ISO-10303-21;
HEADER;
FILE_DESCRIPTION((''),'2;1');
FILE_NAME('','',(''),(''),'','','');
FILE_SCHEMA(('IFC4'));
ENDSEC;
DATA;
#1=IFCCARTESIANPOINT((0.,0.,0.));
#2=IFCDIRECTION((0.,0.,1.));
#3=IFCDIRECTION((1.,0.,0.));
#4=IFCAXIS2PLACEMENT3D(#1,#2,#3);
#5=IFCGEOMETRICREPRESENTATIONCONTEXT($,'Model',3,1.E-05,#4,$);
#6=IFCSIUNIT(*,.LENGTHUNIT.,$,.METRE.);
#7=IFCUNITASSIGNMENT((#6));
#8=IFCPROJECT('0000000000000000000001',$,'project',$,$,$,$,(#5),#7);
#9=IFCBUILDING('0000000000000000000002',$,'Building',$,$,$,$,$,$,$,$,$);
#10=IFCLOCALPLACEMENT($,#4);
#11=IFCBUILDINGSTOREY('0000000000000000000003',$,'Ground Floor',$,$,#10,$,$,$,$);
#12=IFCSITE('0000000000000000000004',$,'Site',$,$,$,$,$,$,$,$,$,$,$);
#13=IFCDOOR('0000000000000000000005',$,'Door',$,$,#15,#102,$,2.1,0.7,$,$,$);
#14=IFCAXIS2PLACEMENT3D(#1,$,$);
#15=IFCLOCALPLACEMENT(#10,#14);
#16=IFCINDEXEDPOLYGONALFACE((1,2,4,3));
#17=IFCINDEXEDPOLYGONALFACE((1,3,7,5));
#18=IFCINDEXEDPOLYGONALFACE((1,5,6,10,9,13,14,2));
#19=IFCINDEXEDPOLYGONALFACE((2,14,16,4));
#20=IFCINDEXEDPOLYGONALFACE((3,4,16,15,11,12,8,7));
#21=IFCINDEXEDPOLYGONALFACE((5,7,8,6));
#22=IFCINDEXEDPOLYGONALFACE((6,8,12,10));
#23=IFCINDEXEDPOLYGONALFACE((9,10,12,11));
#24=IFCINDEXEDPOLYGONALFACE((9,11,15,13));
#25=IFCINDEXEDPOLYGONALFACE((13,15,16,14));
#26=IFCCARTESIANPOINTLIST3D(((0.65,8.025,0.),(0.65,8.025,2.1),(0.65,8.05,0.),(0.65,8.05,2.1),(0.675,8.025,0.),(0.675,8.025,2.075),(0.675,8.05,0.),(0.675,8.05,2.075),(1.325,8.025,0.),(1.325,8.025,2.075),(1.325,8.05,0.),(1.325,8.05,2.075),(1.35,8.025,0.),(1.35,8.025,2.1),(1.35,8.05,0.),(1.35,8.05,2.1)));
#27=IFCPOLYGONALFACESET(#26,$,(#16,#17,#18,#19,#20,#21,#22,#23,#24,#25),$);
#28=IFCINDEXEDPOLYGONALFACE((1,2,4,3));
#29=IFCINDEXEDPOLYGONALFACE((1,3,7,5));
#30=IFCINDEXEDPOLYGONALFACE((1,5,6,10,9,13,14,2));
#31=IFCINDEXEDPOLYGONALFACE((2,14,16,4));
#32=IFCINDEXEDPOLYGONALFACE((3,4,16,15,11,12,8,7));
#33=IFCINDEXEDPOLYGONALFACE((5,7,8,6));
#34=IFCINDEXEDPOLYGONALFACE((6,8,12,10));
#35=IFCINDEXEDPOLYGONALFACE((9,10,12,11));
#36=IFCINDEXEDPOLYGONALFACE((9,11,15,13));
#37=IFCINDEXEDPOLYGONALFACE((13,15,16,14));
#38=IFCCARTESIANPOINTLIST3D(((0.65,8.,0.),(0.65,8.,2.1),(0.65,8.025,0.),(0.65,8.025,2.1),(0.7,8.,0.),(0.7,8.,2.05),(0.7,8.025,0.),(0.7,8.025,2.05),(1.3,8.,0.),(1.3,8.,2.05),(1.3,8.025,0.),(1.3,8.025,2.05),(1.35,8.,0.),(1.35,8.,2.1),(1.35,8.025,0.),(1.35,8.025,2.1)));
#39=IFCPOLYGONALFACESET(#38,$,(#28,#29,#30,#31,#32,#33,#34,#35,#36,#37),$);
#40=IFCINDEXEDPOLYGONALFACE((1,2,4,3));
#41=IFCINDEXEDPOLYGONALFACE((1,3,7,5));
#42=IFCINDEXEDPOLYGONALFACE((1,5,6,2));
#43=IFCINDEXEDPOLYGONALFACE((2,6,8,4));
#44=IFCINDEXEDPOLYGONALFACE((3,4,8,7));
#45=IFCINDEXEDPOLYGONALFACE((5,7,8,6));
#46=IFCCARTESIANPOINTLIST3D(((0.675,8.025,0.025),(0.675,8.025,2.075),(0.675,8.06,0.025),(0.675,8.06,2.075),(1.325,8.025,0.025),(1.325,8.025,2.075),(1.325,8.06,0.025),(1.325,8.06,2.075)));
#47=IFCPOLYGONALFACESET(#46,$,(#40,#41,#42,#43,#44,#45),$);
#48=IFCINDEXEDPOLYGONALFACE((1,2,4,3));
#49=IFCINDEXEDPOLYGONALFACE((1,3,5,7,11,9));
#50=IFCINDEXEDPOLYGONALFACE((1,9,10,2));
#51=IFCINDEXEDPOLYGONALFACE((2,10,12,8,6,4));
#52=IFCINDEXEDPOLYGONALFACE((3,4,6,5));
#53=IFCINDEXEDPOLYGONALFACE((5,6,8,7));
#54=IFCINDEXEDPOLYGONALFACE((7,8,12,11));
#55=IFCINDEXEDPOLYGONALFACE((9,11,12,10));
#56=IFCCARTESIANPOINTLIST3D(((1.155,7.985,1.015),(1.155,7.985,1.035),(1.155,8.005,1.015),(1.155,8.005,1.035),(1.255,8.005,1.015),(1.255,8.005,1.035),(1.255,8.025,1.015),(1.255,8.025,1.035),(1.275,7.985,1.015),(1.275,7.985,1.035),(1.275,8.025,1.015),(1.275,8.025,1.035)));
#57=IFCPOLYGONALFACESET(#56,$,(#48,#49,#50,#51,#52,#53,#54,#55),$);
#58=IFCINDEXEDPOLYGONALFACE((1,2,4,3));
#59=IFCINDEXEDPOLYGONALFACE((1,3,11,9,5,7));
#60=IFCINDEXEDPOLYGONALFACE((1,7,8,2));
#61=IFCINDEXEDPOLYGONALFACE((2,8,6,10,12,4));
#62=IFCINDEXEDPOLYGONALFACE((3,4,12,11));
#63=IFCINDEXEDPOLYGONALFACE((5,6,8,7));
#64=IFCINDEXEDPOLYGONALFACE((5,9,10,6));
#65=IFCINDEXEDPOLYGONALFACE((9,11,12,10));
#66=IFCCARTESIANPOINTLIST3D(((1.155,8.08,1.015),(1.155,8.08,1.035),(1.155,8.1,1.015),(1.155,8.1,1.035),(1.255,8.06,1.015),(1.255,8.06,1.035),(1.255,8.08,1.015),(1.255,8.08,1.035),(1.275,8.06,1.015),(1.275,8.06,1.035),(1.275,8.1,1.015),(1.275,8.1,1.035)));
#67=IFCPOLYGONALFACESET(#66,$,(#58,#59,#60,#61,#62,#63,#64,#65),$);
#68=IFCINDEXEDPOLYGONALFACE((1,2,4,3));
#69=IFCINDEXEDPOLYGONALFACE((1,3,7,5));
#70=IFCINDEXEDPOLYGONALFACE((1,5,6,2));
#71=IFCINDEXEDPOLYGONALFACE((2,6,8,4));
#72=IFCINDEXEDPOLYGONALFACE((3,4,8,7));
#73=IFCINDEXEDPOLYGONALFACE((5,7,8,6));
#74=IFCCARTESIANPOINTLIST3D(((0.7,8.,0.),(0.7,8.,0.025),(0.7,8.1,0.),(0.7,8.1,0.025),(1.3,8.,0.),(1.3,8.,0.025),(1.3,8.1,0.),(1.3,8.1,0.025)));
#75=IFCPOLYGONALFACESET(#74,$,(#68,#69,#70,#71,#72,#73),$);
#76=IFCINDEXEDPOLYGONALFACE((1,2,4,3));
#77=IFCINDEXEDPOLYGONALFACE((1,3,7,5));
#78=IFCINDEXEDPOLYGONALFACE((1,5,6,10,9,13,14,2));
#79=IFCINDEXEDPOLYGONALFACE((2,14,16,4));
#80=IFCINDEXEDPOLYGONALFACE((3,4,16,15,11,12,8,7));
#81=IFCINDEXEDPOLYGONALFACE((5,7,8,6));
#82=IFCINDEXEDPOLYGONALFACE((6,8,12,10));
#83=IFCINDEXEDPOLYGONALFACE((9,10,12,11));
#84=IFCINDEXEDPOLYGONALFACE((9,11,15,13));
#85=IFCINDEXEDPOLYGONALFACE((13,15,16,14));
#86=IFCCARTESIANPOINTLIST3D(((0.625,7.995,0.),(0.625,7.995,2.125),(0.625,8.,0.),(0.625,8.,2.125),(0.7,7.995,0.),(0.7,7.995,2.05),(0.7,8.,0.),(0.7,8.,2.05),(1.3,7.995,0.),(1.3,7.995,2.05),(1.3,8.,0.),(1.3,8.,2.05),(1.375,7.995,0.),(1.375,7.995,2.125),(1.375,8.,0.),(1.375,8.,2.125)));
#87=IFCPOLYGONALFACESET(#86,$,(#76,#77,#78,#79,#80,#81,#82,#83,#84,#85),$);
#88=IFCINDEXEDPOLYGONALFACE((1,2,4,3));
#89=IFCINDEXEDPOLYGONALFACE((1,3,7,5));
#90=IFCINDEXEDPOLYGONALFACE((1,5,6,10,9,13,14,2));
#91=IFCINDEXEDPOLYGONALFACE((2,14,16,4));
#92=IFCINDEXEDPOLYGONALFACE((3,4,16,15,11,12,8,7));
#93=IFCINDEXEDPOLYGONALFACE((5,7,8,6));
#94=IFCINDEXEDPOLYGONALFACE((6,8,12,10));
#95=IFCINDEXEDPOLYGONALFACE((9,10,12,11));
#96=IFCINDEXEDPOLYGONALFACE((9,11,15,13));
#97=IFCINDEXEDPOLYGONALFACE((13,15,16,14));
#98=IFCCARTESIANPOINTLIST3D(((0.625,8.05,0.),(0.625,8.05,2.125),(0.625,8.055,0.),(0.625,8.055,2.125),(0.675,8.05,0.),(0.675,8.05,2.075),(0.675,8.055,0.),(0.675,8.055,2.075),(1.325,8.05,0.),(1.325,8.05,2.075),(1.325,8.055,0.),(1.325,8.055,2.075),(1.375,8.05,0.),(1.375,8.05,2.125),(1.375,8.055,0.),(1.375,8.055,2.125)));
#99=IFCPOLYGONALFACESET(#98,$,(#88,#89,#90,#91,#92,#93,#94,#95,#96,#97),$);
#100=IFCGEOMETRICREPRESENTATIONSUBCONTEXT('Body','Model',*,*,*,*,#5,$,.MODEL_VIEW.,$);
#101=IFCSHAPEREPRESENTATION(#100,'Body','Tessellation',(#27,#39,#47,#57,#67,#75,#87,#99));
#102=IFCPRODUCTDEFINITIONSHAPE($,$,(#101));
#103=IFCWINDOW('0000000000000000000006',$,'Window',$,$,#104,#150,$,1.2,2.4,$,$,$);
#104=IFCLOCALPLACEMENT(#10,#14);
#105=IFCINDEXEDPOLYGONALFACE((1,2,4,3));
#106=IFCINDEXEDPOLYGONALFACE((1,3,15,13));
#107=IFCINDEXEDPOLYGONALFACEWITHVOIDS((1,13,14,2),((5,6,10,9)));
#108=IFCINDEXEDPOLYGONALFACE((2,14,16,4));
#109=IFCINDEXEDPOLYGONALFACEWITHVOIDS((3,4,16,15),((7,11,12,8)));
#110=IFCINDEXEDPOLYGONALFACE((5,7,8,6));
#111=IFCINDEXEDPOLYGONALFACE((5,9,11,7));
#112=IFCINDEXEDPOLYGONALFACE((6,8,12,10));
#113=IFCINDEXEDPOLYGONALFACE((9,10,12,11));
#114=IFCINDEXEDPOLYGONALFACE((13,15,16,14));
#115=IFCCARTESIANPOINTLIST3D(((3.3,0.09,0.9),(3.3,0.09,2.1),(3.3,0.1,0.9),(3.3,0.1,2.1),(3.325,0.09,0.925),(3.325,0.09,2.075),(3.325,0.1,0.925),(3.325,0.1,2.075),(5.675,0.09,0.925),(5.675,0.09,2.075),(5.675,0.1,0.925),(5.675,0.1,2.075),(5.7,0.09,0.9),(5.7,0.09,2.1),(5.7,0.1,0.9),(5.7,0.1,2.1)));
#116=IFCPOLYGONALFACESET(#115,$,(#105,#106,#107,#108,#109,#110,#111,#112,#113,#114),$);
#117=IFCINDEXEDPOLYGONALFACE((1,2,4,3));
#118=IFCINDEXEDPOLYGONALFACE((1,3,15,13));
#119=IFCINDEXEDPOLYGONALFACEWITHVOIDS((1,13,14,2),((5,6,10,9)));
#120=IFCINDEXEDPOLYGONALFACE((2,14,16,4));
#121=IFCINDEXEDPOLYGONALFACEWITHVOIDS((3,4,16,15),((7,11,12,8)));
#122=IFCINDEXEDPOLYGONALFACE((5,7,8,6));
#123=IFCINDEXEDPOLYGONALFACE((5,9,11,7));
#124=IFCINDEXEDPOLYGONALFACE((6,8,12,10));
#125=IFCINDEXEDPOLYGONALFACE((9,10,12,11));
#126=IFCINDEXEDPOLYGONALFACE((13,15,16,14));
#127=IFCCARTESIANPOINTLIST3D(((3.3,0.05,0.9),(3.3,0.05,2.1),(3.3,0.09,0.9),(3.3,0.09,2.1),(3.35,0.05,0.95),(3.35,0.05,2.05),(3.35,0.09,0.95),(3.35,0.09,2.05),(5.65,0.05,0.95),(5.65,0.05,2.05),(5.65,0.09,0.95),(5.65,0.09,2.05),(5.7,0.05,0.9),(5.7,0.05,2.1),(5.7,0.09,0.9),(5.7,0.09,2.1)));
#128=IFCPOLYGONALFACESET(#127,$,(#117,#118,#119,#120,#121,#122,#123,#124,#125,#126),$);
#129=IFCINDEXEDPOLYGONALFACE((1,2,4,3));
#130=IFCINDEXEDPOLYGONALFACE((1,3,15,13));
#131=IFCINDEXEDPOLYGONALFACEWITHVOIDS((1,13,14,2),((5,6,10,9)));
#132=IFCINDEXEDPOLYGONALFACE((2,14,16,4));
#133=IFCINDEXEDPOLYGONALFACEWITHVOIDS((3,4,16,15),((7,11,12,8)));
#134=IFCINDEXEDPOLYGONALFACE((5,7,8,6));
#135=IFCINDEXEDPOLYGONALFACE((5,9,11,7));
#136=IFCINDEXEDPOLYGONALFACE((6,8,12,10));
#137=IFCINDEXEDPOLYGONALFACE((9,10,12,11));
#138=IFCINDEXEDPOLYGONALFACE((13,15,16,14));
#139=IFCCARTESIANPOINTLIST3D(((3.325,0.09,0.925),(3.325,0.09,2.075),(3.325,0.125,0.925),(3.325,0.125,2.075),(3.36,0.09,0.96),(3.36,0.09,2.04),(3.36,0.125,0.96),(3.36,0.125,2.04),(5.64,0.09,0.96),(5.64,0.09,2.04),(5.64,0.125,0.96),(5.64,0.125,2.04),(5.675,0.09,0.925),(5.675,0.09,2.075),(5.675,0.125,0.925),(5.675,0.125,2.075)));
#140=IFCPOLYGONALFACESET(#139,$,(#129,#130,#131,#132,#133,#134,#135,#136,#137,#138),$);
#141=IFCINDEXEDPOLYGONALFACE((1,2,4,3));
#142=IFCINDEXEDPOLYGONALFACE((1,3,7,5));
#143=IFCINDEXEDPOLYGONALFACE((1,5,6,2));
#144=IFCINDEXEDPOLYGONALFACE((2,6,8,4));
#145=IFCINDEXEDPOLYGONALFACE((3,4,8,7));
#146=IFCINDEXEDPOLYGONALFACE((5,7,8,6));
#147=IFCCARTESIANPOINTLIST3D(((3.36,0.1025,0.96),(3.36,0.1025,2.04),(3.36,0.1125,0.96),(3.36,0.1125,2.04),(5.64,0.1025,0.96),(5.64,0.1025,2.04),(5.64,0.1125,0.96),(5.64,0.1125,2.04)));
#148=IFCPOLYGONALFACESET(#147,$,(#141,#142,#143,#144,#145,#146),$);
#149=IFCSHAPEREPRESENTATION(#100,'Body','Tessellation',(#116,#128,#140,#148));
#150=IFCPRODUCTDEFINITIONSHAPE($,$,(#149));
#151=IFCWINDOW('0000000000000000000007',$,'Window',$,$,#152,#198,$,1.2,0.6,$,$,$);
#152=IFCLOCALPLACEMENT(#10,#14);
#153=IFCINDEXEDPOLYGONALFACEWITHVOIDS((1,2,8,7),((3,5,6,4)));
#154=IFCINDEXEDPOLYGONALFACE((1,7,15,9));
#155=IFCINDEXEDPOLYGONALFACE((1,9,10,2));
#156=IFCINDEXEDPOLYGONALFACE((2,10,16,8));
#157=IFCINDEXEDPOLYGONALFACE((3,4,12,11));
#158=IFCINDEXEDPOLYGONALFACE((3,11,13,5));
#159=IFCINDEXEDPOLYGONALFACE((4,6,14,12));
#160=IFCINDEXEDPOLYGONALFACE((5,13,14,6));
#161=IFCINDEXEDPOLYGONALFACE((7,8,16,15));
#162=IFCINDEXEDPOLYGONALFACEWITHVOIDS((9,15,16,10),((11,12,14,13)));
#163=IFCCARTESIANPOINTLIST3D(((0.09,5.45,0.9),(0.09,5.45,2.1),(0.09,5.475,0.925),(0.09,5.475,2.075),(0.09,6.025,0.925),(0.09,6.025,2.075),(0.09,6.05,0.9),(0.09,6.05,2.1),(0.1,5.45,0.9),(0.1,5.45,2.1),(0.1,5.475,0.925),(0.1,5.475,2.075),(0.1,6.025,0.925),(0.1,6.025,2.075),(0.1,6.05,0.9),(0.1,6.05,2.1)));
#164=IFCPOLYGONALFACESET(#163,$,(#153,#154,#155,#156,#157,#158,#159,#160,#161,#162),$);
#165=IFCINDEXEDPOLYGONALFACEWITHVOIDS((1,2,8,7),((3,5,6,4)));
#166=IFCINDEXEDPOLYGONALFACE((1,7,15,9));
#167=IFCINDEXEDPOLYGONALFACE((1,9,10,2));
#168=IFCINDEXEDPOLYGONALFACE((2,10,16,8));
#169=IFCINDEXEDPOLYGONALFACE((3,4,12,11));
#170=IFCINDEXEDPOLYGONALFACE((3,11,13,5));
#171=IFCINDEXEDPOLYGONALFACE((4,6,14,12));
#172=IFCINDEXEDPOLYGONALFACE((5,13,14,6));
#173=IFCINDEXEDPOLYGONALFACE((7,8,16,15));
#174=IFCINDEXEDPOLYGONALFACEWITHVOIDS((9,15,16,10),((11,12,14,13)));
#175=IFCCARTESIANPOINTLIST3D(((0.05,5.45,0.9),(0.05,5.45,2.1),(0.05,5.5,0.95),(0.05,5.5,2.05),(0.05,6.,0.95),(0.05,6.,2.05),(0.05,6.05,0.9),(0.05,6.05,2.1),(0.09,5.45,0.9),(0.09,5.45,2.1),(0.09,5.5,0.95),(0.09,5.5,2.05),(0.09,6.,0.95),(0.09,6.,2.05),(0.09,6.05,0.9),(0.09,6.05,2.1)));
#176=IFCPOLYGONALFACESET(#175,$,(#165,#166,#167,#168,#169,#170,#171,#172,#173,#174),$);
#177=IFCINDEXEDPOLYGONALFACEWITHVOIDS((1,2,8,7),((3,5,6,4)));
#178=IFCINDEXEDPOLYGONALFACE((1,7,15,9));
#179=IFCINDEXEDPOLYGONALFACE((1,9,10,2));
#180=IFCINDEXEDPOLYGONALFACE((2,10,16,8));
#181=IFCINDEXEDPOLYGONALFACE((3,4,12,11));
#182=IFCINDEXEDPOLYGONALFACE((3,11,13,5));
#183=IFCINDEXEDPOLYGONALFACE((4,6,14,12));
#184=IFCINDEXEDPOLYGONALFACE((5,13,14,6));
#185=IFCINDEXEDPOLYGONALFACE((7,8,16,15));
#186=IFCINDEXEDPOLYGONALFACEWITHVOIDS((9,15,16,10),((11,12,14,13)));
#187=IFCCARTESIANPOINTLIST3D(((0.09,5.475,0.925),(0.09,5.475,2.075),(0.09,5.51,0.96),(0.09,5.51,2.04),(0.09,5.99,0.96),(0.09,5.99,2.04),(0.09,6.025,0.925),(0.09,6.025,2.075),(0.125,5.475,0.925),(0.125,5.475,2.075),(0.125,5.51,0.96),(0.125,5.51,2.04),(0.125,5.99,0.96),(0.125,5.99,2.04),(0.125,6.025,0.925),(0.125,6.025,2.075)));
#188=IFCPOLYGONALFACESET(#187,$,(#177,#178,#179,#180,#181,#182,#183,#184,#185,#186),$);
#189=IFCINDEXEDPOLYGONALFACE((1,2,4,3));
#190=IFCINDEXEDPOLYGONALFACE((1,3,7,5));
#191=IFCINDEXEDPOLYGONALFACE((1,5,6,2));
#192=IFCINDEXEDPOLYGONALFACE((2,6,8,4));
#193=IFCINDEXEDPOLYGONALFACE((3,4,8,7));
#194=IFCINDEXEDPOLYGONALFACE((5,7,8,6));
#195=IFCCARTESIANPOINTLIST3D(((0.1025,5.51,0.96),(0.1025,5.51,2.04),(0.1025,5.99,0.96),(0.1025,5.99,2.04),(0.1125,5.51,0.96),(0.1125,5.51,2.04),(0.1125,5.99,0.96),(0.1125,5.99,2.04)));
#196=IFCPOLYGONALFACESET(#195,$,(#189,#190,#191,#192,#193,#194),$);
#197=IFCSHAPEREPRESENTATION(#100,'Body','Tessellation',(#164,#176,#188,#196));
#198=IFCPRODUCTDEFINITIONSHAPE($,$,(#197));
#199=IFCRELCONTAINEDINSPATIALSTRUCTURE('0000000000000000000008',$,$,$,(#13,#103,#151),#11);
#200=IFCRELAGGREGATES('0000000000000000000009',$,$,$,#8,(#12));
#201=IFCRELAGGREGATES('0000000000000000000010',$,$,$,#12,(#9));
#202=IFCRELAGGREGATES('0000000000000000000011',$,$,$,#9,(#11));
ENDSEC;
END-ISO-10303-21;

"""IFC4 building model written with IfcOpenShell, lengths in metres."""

from ifc_helpers import new_model, si_unit, frame, origin_with_axes, place, context, subcontext, project, spatial, line, indexed_curve, outline, extrude, element, save


model = new_model("IFC4")

# Units and contexts
model_context = context("Model", 3, precision=1e-05, world=origin_with_axes())
body_context = subcontext(model_context, "Body", "Model", "MODEL_VIEW")
ifc_project = project(units=[si_unit("LENGTHUNIT", "METRE")], contexts=[model_context])

# Site, building, storey
site = spatial("IfcSite", under=ifc_project, Name="Site")
building = spatial("IfcBuilding", under=site, Name="Building")
storey_placement = place(None, origin_with_axes())
storey = spatial("IfcBuildingStorey", under=building, at=storey_placement, Name="Ground Floor")

# Door
door_1_placement = place(storey_placement, frame((0.65, 8.0, 0.0), z_axis=(0.0, 0.0, 1.0), x_axis=(1.0, 0.0, 0.0)))
element("IfcDoor", 1, at=door_1_placement, inside=storey, Name="Door", OverallHeight=2.1, OverallWidth=0.7, context=body_context, shape_type="SweptSolid", body=[
    extrude(outline(indexed_curve([(0.0, 0.0), (0.0, 2.1), (0.7, 2.1), (0.7, 0.0), (0.675, 0.0), (0.675, 2.075), (0.025, 2.075), (0.025, 0.0)], segments=[line(1, 2, 3, 4, 5, 6, 7, 8, 1)])), frame((0.0, 0.025, 0.0), z_axis=(0.0, -1.0, 0.0), x_axis=(1.0, 0.0, 0.0)), (0.0, 0.0, -1.0), 0.025),
    extrude(outline(indexed_curve([(0.0, 0.0), (0.0, 2.1), (0.7, 2.1), (0.7, 0.0), (0.65, 0.0), (0.65, 2.05), (0.05, 2.05), (0.05, 0.0)], segments=[line(1, 2, 3, 4, 5, 6, 7, 8, 1)])), frame((0.0, 0.0, 0.0), z_axis=(0.0, -1.0, 0.0), x_axis=(1.0, 0.0, 0.0)), (0.0, 0.0, -1.0), 0.025),
    extrude(outline(indexed_curve([(0.0, 0.0), (0.65, 0.0), (0.65, 0.035), (0.0, 0.035)], segments=[line(1, 2, 3, 4, 1)])), frame((0.025, 0.025, 0.025), z_axis=(0.0, 0.0, 1.0), x_axis=(1.0, 0.0, 0.0)), (0.0, 0.0, 1.0), 2.05),
    extrude(outline(indexed_curve([(0.0, 0.0), (0.0, -0.04), (-0.12, -0.04), (-0.12, -0.02), (-0.02, -0.02), (-0.02, 0.0)], segments=[line(1, 2, 3, 4, 5, 6, 1)])), frame((0.625, 0.025, 1.015), z_axis=(0.0, 0.0, 1.0), x_axis=(1.0, 0.0, 0.0)), (0.0, 0.0, 1.0), 0.02),
    extrude(outline(indexed_curve([(0.0, 0.0), (0.0, 0.04), (-0.12, 0.04), (-0.12, 0.02), (-0.02, 0.02), (-0.02, 0.0)], segments=[line(1, 2, 3, 4, 5, 6, 1)])), frame((0.625, 0.06, 1.015), z_axis=(0.0, 0.0, 1.0), x_axis=(1.0, 0.0, 0.0)), (0.0, 0.0, 1.0), 0.02),
    extrude(outline(indexed_curve([(0.0, 0.0), (0.6, 0.0), (0.6, 0.1), (0.0, 0.1)], segments=[line(1, 2, 3, 4, 1)])), frame((0.05, 0.0, 0.0), z_axis=(0.0, 0.0, 1.0), x_axis=(1.0, 0.0, 0.0)), (0.0, 0.0, 1.0), 0.025),
    extrude(outline(indexed_curve([(0.0, 0.0), (0.0, 2.125), (0.75, 2.125), (0.75, 0.0), (0.675, 0.0), (0.675, 2.05), (0.075, 2.05), (0.075, 0.0)], segments=[line(1, 2, 3, 4, 5, 6, 7, 8, 1)])), frame((-0.025, -0.005, 0.0), z_axis=(0.0, -1.0, 0.0), x_axis=(1.0, 0.0, 0.0)), (0.0, 0.0, -1.0), 0.005),
    extrude(outline(indexed_curve([(0.0, 0.0), (0.0, 2.125), (0.75, 2.125), (0.75, 0.0), (0.7, 0.0), (0.7, 2.075), (0.05, 2.075), (0.05, 0.0)], segments=[line(1, 2, 3, 4, 5, 6, 7, 8, 1)])), frame((-0.025, 0.05, 0.0), z_axis=(0.0, -1.0, 0.0), x_axis=(1.0, 0.0, 0.0)), (0.0, 0.0, -1.0), 0.005),
])

# Windows
window_1_placement = place(storey_placement, frame((3.3, 0.0, 0.9), z_axis=(0.0, 0.0, 1.0), x_axis=(1.0, 0.0, 0.0)))
element("IfcWindow", 2, at=window_1_placement, inside=storey, Name="Window", OverallHeight=1.2, OverallWidth=2.4, context=body_context, shape_type="SweptSolid", body=[
    extrude(outline(indexed_curve([(0.0, 0.0), (2.4, 0.0), (2.4, 1.2), (0.0, 1.2)], segments=[line(1, 2, 3, 4, 1)]), holes=[indexed_curve([(0.025, 0.025), (2.375, 0.025), (2.375, 1.175), (0.025, 1.175)], segments=[line(1, 2, 3, 4, 1)])]), frame((0.0, 0.09, 0.0), z_axis=(0.0, -1.0, 0.0), x_axis=(1.0, 0.0, 0.0)), (0.0, 0.0, -1.0), 0.01),
    extrude(outline(indexed_curve([(0.0, 0.0), (2.4, 0.0), (2.4, 1.2), (0.0, 1.2)], segments=[line(1, 2, 3, 4, 1)]), holes=[indexed_curve([(0.05, 0.05), (2.35, 0.05), (2.35, 1.15), (0.05, 1.15)], segments=[line(1, 2, 3, 4, 1)])]), frame((0.0, 0.05, 0.0), z_axis=(0.0, -1.0, 0.0), x_axis=(1.0, 0.0, 0.0)), (0.0, 0.0, -1.0), 0.04),
    extrude(outline(indexed_curve([(0.0, 0.0), (2.35, 0.0), (2.35, 1.15), (0.0, 1.15)], segments=[line(1, 2, 3, 4, 1)]), holes=[indexed_curve([(0.035, 0.035), (2.315, 0.035), (2.315, 1.115), (0.035, 1.115)], segments=[line(1, 2, 3, 4, 1)])]), frame((0.025, 0.09, 0.025), z_axis=(0.0, -1.0, 0.0), x_axis=(1.0, 0.0, 0.0)), (0.0, 0.0, -1.0), 0.035),
    extrude(outline(indexed_curve([(0.035, 0.035), (2.315, 0.035), (2.315, 1.115), (0.035, 1.115)], segments=[line(1, 2, 3, 4, 1)])), frame((0.025, 0.1025, 0.025), z_axis=(0.0, -1.0, 0.0), x_axis=(1.0, 0.0, 0.0)), (0.0, 0.0, -1.0), 0.01),
])
window_2_placement = place(storey_placement, frame((0.0, 6.05, 0.9), z_axis=(0.0, 0.0, 1.0), x_axis=(0.0, -1.0, 0.0)))
element("IfcWindow", 3, at=window_2_placement, inside=storey, Name="Window", OverallHeight=1.2, OverallWidth=0.6, context=body_context, shape_type="SweptSolid", body=[
    extrude(outline(indexed_curve([(0.0, 0.0), (0.6, 0.0), (0.6, 1.2), (0.0, 1.2)], segments=[line(1, 2, 3, 4, 1)]), holes=[indexed_curve([(0.025, 0.025), (0.575, 0.025), (0.575, 1.175), (0.025, 1.175)], segments=[line(1, 2, 3, 4, 1)])]), frame((0.0, 0.09, 0.0), z_axis=(0.0, -1.0, 0.0), x_axis=(1.0, 0.0, 0.0)), (0.0, 0.0, -1.0), 0.01),
    extrude(outline(indexed_curve([(0.0, 0.0), (0.6, 0.0), (0.6, 1.2), (0.0, 1.2)], segments=[line(1, 2, 3, 4, 1)]), holes=[indexed_curve([(0.05, 0.05), (0.55, 0.05), (0.55, 1.15), (0.05, 1.15)], segments=[line(1, 2, 3, 4, 1)])]), frame((0.0, 0.05, 0.0), z_axis=(0.0, -1.0, 0.0), x_axis=(1.0, 0.0, 0.0)), (0.0, 0.0, -1.0), 0.04),
    extrude(outline(indexed_curve([(0.0, 0.0), (0.55, 0.0), (0.55, 1.15), (0.0, 1.15)], segments=[line(1, 2, 3, 4, 1)]), holes=[indexed_curve([(0.035, 0.035), (0.515, 0.035), (0.515, 1.115), (0.035, 1.115)], segments=[line(1, 2, 3, 4, 1)])]), frame((0.025, 0.09, 0.025), z_axis=(0.0, -1.0, 0.0), x_axis=(1.0, 0.0, 0.0)), (0.0, 0.0, -1.0), 0.035),
    extrude(outline(indexed_curve([(0.035, 0.035), (0.515, 0.035), (0.515, 1.115), (0.035, 1.115)], segments=[line(1, 2, 3, 4, 1)])), frame((0.025, 0.1025, 0.025), z_axis=(0.0, -1.0, 0.0), x_axis=(1.0, 0.0, 0.0)), (0.0, 0.0, -1.0), 0.01),
])

save(model, "model.ifc")
